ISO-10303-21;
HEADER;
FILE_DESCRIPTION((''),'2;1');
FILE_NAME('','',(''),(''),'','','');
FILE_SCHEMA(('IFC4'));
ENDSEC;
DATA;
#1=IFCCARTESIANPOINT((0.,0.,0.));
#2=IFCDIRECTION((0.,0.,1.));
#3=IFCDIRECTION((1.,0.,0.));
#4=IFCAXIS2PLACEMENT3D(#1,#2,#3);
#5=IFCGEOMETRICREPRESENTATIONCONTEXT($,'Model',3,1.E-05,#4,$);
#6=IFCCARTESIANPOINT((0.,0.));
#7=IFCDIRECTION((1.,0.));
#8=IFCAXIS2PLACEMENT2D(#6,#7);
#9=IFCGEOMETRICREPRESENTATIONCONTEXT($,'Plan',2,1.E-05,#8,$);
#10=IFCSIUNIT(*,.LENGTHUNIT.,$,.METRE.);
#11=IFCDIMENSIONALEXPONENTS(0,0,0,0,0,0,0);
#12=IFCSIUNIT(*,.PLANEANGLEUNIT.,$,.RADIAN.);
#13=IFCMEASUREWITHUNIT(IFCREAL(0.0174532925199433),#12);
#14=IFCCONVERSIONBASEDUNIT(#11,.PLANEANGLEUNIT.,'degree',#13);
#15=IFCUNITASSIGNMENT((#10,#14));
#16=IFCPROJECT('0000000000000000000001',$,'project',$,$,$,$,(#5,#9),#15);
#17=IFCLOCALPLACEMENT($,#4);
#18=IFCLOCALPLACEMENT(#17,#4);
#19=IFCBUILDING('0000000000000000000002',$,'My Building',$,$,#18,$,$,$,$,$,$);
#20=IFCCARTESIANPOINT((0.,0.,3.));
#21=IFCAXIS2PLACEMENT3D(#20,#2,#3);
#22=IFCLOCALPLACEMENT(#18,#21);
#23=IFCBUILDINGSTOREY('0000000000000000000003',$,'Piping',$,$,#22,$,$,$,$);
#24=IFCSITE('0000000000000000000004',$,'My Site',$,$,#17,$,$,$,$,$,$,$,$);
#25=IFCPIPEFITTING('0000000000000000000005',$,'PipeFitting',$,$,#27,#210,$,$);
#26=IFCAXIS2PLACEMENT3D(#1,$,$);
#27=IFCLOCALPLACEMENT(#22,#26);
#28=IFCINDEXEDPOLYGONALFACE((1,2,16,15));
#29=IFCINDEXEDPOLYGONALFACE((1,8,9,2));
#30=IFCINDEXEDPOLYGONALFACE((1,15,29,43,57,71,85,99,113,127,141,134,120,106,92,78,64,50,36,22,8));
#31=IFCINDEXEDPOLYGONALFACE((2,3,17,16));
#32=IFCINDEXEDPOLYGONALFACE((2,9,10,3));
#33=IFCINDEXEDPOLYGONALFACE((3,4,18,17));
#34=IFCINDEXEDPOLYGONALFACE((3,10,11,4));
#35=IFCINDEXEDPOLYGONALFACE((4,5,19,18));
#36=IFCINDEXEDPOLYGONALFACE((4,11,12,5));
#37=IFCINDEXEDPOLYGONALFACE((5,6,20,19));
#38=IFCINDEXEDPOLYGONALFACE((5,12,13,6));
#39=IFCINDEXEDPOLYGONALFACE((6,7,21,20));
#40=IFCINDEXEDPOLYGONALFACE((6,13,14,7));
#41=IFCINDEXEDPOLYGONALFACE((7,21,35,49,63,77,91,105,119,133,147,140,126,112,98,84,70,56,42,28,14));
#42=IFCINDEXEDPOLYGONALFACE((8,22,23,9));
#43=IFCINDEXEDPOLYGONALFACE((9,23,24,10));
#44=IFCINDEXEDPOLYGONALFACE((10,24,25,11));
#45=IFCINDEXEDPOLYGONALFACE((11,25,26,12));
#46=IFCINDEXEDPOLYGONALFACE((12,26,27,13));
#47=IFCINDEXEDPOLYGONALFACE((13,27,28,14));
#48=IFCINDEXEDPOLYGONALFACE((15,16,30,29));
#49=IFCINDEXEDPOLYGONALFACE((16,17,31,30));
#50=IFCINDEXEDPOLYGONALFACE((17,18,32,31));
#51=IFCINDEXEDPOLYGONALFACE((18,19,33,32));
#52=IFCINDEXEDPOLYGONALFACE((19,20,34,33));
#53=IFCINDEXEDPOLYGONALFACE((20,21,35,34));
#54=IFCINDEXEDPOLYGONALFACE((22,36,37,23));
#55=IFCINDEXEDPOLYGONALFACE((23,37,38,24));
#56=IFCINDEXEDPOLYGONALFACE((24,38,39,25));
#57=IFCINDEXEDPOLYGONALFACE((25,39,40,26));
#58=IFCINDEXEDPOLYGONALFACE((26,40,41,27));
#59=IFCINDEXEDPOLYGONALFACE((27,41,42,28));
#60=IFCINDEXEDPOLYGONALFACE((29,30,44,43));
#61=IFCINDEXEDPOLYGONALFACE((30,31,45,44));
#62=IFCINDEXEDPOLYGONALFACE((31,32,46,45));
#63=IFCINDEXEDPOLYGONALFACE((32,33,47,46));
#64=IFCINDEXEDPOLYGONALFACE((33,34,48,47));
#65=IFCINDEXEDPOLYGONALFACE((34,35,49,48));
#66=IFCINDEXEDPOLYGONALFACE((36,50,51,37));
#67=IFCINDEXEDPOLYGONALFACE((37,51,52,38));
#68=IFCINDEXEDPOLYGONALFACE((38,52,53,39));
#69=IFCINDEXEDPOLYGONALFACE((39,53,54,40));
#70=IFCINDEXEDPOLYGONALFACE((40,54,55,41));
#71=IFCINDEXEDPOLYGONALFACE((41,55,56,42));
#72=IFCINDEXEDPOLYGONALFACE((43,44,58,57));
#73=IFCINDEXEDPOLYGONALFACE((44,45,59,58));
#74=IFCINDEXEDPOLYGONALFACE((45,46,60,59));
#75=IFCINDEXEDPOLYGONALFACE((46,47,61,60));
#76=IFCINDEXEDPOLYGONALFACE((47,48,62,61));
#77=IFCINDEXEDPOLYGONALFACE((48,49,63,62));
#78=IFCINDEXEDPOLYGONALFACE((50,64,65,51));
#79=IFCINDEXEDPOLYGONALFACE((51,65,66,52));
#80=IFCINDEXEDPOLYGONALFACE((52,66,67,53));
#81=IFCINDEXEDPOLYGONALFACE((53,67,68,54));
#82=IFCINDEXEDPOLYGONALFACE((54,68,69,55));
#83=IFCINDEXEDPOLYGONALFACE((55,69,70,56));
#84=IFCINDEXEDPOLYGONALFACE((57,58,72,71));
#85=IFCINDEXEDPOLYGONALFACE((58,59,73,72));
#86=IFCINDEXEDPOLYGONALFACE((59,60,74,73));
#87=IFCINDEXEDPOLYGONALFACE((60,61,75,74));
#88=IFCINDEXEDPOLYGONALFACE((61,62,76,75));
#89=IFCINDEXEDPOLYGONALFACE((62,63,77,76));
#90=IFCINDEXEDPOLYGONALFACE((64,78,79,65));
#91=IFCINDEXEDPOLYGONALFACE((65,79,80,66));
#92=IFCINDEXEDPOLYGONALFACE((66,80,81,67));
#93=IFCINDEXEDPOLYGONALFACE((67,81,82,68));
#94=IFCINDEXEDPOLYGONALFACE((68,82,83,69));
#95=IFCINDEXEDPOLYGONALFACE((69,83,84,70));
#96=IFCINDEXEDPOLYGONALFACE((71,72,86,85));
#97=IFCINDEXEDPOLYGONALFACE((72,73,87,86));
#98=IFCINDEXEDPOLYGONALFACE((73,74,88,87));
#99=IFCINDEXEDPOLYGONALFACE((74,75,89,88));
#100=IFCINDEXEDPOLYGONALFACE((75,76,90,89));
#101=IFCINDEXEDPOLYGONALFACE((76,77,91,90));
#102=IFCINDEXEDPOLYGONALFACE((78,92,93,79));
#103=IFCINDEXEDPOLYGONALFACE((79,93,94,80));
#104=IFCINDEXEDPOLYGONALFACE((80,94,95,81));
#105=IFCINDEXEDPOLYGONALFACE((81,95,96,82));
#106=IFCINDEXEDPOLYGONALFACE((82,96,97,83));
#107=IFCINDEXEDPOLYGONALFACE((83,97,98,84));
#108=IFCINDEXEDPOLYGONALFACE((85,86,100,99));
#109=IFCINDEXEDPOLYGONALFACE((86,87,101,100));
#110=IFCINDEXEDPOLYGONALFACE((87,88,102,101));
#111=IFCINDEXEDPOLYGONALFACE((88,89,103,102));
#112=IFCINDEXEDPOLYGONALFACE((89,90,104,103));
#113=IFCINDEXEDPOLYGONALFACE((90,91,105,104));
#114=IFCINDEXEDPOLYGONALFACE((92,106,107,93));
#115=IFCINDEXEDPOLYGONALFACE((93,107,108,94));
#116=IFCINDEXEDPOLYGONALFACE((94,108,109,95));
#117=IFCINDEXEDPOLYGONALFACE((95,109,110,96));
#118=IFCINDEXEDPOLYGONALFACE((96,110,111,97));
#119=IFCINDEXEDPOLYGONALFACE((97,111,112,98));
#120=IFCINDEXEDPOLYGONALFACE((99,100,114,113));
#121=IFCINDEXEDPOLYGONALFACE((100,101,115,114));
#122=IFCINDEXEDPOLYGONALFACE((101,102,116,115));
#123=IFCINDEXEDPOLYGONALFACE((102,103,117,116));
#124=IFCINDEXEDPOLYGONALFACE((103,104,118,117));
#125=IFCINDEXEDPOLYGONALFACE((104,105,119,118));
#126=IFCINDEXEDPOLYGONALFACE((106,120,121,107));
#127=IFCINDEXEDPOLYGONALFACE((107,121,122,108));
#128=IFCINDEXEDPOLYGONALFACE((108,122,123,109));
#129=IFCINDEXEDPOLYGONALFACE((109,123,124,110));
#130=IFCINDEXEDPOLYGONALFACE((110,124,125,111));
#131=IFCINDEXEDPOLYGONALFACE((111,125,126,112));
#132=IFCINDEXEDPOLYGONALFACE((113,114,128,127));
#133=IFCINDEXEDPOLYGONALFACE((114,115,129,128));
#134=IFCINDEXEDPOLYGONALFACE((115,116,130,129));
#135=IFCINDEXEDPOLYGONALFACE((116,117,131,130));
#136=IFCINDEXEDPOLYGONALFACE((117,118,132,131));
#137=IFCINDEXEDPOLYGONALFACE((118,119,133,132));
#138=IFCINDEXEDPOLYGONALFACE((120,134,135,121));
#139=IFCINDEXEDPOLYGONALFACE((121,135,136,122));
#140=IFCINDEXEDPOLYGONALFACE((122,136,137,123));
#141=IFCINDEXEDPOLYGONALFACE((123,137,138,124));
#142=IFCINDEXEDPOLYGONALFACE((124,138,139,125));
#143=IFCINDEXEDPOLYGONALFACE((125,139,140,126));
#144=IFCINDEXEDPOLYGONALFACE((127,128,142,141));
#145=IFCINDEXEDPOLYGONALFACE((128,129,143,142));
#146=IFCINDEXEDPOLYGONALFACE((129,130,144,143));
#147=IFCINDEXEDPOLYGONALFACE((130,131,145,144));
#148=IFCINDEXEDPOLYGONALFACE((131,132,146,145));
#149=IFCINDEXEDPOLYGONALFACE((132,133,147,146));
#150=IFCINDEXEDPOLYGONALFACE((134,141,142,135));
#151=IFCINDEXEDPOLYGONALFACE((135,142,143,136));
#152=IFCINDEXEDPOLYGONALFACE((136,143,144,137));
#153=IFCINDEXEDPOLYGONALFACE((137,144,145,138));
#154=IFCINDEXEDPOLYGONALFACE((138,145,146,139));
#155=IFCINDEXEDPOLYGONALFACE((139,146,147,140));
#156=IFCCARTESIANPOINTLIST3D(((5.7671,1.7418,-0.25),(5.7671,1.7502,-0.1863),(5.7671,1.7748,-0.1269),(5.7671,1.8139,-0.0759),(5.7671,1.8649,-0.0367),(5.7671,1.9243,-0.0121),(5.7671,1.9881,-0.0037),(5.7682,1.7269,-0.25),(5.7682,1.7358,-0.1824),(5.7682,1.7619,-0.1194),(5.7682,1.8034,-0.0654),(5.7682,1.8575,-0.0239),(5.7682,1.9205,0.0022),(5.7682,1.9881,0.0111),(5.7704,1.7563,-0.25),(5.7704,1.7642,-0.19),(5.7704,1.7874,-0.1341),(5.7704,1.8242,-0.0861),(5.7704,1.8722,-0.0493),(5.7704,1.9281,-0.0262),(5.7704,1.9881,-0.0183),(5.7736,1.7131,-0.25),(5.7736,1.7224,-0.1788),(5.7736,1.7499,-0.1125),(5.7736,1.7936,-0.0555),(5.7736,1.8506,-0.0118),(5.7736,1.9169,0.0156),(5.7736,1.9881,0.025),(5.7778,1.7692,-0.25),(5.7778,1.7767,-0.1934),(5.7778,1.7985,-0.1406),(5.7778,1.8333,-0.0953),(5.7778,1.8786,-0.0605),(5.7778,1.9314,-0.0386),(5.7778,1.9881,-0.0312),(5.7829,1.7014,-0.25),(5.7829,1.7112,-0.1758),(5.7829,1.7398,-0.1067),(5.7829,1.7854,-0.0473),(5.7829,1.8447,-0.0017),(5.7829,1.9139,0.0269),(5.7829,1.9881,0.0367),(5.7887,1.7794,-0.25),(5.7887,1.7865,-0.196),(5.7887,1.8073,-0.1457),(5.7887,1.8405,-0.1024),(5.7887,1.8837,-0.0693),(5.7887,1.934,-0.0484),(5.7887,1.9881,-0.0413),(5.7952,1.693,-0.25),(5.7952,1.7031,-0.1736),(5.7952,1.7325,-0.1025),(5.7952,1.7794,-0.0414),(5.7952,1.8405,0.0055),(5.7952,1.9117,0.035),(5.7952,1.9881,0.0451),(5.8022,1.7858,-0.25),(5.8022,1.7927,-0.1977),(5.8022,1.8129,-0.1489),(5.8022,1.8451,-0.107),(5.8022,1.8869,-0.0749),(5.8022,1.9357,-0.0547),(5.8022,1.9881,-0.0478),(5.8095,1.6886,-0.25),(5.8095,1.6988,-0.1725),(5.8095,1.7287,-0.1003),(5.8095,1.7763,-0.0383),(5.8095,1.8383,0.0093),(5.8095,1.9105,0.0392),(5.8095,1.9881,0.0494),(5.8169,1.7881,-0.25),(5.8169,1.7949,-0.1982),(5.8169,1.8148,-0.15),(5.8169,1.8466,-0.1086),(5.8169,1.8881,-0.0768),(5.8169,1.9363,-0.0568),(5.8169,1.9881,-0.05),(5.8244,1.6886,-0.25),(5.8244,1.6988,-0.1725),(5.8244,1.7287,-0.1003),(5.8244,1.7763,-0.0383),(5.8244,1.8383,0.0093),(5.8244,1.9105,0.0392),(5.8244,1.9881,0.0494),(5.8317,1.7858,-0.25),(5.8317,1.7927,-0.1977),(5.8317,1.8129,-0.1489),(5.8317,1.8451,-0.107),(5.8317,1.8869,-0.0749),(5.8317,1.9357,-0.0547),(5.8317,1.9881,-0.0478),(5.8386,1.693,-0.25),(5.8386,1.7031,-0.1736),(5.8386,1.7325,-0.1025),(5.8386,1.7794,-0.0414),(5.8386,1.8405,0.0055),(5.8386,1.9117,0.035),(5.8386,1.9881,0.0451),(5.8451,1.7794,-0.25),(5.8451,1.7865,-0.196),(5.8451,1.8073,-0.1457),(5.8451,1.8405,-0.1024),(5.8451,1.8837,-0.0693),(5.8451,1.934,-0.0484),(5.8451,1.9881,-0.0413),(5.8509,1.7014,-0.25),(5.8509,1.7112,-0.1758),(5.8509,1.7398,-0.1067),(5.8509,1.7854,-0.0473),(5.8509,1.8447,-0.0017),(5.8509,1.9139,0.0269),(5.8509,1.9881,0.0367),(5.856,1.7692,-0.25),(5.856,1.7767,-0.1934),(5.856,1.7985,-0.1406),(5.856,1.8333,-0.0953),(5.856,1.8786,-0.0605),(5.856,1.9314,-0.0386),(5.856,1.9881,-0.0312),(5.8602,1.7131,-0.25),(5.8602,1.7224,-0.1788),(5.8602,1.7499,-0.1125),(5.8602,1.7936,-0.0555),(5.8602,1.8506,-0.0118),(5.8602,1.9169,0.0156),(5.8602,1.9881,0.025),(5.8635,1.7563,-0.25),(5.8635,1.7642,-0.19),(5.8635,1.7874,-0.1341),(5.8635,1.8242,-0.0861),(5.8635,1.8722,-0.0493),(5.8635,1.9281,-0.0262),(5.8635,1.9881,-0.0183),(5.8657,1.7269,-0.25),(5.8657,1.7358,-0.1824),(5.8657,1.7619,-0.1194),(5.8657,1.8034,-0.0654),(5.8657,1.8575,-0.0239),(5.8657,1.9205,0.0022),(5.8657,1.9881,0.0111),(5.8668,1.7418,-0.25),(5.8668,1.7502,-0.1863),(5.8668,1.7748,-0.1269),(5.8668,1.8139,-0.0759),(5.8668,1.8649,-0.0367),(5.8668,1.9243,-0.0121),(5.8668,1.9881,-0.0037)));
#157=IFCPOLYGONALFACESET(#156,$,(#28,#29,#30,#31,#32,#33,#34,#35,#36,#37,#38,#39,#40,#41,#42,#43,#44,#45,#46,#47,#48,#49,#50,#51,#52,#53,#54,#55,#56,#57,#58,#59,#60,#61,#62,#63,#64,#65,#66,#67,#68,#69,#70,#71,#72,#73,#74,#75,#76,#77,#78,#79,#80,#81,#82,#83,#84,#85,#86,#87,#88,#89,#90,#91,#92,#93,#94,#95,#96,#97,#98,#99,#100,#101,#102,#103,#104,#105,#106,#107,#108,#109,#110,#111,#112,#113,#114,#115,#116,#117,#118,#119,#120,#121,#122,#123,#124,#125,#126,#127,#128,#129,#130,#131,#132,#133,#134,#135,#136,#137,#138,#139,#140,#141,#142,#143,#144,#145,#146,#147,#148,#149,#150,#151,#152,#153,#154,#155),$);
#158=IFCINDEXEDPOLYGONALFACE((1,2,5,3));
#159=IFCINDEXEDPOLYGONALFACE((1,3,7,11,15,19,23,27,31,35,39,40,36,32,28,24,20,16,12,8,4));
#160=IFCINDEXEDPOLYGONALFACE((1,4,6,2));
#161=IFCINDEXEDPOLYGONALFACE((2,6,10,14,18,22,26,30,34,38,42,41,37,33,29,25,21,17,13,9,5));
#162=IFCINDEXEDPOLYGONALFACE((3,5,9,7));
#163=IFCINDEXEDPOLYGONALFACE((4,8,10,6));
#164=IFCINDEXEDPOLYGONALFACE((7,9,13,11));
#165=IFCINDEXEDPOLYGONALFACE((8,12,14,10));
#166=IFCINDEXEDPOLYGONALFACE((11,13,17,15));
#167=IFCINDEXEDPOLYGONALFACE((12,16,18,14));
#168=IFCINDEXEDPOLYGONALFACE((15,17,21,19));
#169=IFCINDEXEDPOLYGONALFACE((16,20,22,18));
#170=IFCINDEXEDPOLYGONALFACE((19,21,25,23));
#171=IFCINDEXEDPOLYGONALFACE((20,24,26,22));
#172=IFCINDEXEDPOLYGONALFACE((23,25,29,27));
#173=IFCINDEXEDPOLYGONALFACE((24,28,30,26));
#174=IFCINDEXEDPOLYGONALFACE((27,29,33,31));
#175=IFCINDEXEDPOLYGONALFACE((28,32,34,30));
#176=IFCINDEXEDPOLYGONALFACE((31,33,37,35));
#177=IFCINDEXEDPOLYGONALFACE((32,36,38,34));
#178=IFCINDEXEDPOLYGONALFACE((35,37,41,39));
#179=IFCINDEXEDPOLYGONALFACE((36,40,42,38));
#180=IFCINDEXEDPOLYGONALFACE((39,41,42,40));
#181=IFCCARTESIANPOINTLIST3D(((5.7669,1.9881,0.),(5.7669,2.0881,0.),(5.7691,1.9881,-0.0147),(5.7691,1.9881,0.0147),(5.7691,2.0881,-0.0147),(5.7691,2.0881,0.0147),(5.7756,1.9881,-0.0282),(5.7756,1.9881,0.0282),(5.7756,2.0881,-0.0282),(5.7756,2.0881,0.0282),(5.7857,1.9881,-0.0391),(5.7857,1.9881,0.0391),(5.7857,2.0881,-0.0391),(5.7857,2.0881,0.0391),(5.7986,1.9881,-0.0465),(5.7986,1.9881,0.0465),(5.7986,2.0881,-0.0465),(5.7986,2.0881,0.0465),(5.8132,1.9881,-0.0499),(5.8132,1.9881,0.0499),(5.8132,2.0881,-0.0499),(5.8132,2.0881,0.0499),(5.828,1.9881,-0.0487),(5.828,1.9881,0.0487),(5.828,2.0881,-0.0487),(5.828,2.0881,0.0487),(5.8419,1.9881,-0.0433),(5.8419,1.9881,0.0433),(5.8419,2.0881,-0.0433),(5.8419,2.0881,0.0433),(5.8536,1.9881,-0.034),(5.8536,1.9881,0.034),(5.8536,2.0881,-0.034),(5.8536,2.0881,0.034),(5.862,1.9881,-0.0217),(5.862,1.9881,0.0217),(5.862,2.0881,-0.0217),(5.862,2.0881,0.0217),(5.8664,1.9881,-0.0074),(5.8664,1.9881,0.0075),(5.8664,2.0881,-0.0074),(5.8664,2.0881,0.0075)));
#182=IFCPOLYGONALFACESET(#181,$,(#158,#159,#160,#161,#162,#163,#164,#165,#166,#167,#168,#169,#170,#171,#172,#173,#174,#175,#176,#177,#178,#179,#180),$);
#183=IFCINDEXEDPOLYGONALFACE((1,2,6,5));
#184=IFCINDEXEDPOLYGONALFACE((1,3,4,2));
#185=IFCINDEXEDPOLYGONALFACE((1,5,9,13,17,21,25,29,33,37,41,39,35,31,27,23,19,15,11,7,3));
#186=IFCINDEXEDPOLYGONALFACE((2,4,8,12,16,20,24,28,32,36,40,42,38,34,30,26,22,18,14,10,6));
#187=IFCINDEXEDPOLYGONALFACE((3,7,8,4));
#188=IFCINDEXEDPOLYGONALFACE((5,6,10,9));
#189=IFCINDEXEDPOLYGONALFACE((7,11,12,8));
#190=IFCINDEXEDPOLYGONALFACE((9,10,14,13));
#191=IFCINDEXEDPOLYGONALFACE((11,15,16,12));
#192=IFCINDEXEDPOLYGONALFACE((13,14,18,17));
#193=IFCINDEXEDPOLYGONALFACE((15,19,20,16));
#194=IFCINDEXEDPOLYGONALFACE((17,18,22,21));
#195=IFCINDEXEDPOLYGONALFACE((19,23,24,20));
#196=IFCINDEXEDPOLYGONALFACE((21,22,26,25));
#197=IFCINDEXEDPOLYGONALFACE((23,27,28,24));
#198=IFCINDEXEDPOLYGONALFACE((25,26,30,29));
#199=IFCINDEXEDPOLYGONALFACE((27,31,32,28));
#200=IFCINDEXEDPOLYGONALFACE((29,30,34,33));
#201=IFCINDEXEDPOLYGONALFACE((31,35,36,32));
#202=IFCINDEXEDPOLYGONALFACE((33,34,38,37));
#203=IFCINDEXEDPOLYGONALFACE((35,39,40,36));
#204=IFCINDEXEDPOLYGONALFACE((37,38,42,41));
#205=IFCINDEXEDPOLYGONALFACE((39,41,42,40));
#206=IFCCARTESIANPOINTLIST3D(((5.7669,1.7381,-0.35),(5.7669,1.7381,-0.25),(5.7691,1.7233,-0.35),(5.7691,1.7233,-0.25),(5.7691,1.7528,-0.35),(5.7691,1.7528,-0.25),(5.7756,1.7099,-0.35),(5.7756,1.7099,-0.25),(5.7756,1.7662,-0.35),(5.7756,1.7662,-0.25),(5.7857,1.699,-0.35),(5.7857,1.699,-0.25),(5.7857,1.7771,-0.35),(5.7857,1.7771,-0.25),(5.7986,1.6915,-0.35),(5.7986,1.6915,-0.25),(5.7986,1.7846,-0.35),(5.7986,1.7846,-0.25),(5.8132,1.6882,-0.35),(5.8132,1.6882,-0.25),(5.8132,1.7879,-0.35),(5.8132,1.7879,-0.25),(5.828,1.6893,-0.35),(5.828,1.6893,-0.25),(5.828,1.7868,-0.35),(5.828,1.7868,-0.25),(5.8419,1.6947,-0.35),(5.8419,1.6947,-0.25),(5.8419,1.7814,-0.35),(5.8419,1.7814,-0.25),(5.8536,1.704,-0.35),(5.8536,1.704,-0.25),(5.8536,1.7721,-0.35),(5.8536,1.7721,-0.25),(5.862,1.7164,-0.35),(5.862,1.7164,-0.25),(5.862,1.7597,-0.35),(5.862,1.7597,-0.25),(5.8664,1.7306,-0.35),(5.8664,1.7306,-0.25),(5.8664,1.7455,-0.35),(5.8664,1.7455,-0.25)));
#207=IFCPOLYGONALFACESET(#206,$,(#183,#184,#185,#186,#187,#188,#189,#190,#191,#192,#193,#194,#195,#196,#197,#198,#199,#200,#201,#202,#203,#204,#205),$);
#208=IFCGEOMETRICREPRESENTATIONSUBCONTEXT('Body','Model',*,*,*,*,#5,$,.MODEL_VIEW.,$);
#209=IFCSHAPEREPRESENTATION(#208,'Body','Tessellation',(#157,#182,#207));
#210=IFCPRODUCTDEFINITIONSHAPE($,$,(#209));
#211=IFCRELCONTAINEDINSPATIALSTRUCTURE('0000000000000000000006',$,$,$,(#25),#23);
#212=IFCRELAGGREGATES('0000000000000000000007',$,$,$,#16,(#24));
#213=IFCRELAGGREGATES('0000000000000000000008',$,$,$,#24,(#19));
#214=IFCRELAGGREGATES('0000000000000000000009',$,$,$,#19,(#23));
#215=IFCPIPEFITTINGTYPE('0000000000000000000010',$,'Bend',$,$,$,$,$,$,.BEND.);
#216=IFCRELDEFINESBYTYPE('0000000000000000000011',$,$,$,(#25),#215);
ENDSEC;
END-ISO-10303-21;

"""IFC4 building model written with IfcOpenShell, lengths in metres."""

from ifc_helpers import new_model, entity, si_unit, converted_unit, frame, origin_with_axes, origin_2d_with_axis, place, context, subcontext, project, spatial, circle, extrude, source, transform, mapped, type_object, type_shapes, element, save


model = new_model("IFC4")

# Units and contexts
model_context = context("Model", 3, precision=1e-05, world=origin_with_axes())
plan_context = context("Plan", 2, precision=1e-05, world=origin_2d_with_axis())
body_context = subcontext(model_context, "Body", "Model", "MODEL_VIEW")
ifc_project = project(units=[si_unit("LENGTHUNIT", "METRE"), converted_unit("PLANEANGLEUNIT", "degree", entity("IfcReal", 0.0174532925199433), si_unit("PLANEANGLEUNIT", "RADIAN"), dimensions=[0, 0, 0, 0, 0, 0, 0])], contexts=[model_context, plan_context])

# Site, building, storey
site_placement = place(None, origin_with_axes())
site = spatial("IfcSite", under=ifc_project, at=site_placement, Name="My Site")
building_placement = place(site_placement, origin_with_axes())
building = spatial("IfcBuilding", under=site, at=building_placement, Name="My Building")
storey_placement = place(building_placement, frame((0.0, 0.0, 3.0), z_axis=(0.0, 0.0, 1.0), x_axis=(1.0, 0.0, 0.0)))
storey = spatial("IfcBuildingStorey", under=building, at=storey_placement, Name="Piping")

# Pipe fitting
pipe_fitting_type = type_object("IfcPipeFittingType", Name="Bend", PredefinedType="BEND")
shared_shape = source(origin_with_axes(), body_context, "Body", "SolidModel", [
    entity("IfcSweptDiskSolid", entity("IfcIndexedPolyCurve", entity("IfcCartesianPointList3D", [[0.0, 0.0, -0.1], [0.0, -0.0732, -0.2768], [0.0, -0.25, -0.35]]), [entity("IfcArcIndex", [1, 2, 3])]), 0.05),
    extrude(circle(Radius=0.05), origin_with_axes(), (0.0, 0.0, -1.0), 0.1),
    extrude(circle(Radius=0.05), frame((0.0, -0.25, -0.35), z_axis=(0.0, -1.0, 0.0), x_axis=(1.0, 0.0, 0.0)), (0.0, 0.0, 1.0), 0.1),
])
type_shapes(pipe_fitting_type, [shared_shape])
for number, where, z_axis, x_axis, name in (
    (1, (5.8169, 2.0881, 0.0), (0.0, 1.0, 0.0), (-1.0, 0.0, 0.0), "PipeFitting"),
):
    element("IfcPipeFitting", number, at=place(storey_placement, frame(where, z_axis=z_axis, x_axis=x_axis)), inside=storey, type_object=pipe_fitting_type, Name=name, context=body_context, shape_type="MappedRepresentation", body=[
        mapped(shared_shape, transform((0.0, 0.0, 0.0), x_axis=(1.0, 0.0, 0.0), y_axis=(0.0, 1.0, 0.0), z_axis=(0.0, 0.0, 1.0), scale=1.0)),
    ])

save(model, "model.ifc")
